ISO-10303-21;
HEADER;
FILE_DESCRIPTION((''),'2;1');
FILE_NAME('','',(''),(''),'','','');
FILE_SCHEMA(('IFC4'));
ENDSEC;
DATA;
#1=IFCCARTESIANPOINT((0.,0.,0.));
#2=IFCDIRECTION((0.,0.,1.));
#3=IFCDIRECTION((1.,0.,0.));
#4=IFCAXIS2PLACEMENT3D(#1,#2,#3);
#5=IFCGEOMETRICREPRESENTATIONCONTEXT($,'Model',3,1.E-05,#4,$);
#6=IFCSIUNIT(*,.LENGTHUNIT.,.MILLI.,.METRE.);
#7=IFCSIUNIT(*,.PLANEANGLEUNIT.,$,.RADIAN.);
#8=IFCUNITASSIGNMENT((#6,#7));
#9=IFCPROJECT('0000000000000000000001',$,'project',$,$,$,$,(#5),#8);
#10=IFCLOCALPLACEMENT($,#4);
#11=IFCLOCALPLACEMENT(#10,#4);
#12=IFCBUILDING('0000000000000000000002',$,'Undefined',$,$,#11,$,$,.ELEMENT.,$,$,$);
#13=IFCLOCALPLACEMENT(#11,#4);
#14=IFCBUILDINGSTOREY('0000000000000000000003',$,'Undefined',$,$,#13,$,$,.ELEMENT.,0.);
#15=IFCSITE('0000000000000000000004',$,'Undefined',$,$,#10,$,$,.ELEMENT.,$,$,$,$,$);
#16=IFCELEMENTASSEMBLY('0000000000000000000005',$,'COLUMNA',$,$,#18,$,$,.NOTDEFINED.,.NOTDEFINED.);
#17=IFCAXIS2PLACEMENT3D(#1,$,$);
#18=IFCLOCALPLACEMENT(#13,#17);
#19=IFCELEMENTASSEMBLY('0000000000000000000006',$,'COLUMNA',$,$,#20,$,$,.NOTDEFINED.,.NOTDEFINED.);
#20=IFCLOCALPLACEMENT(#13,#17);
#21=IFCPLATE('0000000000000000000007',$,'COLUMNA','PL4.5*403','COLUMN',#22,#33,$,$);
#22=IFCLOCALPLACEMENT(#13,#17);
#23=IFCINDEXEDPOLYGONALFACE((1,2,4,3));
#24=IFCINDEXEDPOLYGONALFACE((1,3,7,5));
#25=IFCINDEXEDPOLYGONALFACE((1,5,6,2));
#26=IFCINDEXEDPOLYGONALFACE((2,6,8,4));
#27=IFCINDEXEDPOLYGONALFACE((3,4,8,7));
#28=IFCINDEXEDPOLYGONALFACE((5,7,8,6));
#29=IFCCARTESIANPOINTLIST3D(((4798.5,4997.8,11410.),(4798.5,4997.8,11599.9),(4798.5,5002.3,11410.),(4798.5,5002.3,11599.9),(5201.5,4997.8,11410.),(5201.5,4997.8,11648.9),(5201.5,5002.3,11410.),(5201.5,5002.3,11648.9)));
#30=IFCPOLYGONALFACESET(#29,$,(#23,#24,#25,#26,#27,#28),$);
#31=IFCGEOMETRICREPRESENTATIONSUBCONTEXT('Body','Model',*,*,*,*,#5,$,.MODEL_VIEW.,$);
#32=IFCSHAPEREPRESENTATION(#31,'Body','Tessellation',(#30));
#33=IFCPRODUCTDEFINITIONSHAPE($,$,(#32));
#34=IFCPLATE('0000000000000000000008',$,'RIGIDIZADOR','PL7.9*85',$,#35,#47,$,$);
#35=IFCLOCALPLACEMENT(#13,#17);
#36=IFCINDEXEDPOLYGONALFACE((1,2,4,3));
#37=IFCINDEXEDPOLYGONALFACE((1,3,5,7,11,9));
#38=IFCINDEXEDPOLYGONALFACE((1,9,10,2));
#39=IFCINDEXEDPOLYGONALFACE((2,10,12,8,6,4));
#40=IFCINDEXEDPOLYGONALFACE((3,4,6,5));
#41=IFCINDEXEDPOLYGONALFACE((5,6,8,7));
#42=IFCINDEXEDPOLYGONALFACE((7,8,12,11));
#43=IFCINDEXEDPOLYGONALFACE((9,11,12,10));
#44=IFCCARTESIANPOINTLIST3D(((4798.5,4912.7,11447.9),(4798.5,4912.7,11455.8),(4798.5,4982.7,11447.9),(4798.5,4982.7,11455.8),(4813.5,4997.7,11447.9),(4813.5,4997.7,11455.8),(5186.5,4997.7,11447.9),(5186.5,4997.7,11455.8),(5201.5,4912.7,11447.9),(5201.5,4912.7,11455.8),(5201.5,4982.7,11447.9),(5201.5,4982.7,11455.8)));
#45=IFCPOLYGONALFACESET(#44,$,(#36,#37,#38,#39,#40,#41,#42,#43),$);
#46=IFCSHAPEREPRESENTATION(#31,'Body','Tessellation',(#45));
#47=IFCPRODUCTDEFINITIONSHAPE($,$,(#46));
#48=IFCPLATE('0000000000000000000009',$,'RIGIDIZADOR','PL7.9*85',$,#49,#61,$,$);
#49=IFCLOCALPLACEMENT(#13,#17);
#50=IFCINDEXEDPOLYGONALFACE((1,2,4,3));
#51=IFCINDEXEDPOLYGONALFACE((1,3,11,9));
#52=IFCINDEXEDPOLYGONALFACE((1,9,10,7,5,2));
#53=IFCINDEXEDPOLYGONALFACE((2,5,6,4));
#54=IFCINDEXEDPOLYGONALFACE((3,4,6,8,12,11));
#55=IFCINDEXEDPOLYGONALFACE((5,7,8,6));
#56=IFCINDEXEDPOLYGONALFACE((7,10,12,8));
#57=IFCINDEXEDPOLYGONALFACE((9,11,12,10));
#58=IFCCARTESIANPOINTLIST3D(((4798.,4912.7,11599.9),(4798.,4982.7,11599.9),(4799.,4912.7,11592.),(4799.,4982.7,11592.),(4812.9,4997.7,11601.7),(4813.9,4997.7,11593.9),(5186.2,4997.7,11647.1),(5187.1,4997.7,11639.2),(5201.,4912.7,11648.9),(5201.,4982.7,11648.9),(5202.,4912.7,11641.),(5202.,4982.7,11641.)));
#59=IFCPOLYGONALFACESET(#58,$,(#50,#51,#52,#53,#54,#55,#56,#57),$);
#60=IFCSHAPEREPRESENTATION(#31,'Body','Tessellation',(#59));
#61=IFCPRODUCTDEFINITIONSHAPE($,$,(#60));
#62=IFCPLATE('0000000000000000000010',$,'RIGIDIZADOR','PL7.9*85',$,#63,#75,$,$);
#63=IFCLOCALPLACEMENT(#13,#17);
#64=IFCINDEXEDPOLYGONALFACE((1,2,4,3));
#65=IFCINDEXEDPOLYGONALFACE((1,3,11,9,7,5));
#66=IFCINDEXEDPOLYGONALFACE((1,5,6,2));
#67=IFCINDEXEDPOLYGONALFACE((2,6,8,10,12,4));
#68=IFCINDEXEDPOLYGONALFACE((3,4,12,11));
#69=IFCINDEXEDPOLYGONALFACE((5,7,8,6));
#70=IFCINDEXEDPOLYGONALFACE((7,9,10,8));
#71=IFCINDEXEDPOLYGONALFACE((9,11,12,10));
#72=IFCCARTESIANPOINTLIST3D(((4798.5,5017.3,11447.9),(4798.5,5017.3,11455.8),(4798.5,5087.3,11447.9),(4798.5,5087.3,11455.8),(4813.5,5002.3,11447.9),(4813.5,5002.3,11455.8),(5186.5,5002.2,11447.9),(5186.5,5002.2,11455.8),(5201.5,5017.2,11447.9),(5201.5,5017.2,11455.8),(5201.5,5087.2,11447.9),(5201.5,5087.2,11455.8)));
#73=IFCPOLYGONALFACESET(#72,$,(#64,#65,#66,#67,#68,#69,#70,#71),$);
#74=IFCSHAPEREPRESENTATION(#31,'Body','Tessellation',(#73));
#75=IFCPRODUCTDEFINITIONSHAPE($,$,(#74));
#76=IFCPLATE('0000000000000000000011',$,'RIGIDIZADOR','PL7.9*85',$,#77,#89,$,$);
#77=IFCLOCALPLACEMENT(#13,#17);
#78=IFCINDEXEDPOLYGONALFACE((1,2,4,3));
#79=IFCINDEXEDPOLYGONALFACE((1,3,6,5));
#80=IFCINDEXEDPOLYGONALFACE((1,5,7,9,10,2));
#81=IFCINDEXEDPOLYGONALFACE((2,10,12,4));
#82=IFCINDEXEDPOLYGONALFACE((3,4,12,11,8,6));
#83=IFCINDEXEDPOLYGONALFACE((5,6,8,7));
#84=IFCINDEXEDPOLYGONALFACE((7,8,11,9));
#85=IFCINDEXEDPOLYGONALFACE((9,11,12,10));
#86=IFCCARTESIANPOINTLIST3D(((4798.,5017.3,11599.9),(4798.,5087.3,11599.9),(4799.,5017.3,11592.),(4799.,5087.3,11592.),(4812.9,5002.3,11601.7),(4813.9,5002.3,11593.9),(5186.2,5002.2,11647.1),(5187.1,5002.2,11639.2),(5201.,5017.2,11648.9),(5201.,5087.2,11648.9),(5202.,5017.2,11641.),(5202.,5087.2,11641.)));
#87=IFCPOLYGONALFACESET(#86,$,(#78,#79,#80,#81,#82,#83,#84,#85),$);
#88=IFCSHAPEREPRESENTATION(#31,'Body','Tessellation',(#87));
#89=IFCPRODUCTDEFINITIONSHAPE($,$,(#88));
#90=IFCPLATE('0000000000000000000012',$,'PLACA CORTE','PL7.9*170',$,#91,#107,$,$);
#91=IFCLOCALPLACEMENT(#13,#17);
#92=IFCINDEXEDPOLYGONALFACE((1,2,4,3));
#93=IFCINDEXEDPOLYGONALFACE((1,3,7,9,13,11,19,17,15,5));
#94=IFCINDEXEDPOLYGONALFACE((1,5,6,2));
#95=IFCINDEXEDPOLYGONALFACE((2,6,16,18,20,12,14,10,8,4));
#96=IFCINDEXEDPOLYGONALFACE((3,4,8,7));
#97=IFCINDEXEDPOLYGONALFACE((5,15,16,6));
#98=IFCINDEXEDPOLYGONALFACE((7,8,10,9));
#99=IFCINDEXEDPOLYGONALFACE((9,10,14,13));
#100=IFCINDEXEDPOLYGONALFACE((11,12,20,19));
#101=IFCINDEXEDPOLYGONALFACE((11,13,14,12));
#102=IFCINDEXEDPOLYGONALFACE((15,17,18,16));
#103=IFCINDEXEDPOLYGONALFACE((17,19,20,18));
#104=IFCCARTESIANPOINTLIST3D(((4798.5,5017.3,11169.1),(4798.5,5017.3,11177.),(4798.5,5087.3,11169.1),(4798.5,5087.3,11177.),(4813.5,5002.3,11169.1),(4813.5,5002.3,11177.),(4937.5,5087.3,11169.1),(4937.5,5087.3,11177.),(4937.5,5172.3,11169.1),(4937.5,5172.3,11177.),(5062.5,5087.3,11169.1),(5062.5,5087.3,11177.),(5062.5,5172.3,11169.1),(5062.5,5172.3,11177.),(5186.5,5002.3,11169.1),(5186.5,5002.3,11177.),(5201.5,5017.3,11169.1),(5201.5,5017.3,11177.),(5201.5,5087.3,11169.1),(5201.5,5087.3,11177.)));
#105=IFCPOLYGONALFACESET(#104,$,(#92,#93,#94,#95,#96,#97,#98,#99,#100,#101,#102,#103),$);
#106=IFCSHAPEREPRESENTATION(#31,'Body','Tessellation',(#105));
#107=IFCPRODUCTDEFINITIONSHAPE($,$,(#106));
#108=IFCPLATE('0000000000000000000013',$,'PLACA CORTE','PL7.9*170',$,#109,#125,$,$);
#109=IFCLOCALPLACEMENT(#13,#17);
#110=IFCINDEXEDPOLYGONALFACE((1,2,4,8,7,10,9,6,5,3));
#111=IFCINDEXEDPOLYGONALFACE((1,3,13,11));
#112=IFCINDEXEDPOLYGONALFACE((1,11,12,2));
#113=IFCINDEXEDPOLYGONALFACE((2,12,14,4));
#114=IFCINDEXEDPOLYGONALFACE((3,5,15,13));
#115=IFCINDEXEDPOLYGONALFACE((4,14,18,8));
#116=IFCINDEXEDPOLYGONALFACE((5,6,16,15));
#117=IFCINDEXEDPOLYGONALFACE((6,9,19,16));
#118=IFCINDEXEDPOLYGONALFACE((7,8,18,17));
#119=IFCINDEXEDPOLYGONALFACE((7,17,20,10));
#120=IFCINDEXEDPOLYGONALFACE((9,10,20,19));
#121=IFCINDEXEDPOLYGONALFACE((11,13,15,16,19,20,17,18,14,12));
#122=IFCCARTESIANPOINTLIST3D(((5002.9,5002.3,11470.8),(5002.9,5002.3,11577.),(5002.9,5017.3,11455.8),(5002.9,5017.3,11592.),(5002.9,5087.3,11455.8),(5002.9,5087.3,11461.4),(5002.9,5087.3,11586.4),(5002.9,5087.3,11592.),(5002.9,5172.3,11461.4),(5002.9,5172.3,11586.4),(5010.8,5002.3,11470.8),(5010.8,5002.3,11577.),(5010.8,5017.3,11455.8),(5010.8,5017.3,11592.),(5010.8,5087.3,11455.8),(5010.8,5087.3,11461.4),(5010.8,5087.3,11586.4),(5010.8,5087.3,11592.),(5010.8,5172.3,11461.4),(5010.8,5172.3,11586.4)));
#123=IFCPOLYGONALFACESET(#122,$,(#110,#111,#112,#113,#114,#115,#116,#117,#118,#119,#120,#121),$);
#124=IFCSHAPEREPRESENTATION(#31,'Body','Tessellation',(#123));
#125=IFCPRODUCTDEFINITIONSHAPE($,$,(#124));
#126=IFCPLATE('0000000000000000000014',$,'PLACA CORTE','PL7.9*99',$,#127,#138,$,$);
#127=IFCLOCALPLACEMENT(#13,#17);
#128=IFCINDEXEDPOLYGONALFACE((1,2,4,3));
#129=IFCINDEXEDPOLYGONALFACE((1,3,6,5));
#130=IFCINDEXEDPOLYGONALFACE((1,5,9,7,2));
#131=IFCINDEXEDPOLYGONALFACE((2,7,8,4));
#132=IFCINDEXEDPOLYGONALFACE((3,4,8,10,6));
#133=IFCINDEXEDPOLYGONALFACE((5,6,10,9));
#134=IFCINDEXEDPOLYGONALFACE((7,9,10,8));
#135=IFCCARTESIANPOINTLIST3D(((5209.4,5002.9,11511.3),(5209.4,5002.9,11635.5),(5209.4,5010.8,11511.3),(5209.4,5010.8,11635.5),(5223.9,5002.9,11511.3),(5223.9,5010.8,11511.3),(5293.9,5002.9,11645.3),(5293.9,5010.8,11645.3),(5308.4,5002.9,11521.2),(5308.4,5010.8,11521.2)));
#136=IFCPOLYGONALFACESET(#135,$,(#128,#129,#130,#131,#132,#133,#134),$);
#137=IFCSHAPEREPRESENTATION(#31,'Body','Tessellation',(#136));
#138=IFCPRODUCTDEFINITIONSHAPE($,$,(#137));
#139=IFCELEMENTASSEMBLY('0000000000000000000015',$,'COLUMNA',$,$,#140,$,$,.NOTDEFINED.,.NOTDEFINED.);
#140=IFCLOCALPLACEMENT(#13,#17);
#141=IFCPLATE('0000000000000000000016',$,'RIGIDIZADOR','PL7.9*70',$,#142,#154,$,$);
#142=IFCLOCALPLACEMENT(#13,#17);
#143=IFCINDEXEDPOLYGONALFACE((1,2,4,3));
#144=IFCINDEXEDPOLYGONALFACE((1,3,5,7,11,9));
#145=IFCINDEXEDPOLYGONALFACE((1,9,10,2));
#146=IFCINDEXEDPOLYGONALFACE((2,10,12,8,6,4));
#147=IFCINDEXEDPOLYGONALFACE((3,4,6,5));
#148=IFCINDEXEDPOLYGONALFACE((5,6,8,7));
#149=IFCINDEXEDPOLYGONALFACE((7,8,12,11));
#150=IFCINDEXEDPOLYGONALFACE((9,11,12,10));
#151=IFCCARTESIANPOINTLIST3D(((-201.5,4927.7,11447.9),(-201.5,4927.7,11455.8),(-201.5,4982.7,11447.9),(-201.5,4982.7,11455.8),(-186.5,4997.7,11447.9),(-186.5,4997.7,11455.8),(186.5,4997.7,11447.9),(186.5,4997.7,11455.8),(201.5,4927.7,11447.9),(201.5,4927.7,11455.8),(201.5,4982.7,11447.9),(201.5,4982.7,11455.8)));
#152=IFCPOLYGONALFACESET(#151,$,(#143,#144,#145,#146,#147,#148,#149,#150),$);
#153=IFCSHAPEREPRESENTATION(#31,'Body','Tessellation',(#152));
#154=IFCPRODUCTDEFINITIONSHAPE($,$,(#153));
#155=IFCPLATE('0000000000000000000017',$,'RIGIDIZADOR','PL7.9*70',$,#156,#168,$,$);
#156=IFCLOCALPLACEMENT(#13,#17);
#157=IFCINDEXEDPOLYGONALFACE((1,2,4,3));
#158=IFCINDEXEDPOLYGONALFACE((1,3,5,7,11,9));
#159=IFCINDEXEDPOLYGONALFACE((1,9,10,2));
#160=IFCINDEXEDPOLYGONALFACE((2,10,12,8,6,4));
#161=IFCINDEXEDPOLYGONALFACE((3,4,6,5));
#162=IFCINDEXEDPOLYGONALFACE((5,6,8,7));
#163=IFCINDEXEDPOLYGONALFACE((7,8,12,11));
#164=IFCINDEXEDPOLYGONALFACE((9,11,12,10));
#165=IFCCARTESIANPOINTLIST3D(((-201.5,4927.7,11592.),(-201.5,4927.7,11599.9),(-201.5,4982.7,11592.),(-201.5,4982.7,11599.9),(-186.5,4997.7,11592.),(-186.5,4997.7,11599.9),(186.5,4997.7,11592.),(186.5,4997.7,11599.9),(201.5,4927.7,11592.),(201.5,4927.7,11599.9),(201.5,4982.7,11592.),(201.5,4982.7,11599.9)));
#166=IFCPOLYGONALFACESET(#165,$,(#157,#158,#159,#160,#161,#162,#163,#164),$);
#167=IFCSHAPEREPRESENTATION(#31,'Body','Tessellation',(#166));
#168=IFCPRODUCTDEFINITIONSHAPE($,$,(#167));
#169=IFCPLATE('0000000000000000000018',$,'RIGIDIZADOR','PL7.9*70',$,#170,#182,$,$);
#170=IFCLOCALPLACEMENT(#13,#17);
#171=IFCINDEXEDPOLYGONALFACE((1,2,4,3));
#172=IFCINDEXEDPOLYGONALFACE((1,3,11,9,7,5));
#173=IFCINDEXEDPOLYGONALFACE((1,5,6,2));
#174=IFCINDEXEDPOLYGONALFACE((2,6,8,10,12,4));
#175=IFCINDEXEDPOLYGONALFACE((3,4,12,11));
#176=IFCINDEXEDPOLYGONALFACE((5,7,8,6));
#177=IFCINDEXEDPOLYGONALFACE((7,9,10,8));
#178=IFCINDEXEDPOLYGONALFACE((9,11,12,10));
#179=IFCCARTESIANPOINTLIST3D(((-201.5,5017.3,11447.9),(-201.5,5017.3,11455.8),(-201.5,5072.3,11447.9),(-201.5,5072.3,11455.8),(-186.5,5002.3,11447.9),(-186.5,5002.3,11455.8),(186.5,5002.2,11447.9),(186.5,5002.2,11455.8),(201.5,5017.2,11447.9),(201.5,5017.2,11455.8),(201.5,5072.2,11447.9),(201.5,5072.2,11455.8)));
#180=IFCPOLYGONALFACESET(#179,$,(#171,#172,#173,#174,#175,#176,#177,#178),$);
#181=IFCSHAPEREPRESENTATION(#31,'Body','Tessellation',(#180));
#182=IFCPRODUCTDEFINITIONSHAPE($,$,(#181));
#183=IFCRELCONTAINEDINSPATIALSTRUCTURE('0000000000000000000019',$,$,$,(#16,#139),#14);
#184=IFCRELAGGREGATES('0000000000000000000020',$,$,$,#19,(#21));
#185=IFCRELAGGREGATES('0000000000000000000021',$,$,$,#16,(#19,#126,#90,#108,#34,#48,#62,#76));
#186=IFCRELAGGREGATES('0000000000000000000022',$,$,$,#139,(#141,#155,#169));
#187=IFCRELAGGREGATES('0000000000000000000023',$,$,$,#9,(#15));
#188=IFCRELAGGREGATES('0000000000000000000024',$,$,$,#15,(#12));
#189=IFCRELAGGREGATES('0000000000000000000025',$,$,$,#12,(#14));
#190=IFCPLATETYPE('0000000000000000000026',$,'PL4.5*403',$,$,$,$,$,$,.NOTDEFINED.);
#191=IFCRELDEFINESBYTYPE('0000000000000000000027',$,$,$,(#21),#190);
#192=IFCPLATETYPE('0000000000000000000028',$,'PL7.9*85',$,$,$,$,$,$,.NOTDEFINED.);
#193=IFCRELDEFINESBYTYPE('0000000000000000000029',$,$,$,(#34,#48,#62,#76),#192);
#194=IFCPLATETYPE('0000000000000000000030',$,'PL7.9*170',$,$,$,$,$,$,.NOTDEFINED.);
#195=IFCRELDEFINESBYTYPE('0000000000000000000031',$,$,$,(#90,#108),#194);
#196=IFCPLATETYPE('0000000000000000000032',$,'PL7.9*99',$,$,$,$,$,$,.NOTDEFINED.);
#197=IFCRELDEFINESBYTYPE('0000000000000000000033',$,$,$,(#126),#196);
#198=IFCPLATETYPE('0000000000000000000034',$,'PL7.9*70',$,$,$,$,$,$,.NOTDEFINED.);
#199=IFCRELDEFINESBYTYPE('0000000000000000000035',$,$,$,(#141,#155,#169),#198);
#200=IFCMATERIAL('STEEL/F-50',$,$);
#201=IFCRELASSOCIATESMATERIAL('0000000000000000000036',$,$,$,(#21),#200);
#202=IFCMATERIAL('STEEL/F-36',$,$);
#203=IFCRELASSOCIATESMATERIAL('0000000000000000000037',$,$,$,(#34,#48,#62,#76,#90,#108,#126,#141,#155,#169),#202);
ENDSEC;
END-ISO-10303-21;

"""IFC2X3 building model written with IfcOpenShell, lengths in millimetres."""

from ifc_helpers import new_model, si_unit, frame, origin_with_axes, place, context, subcontext, project, spatial, polyline, outline, extrude, boolean, material, type_object, element, aggregate, save


model = new_model("IFC2X3")

# Units and contexts
model_context = context("Model", 3, precision=1e-05, world=origin_with_axes())
body_context = subcontext(model_context, "Body", "Model", "MODEL_VIEW")
ifc_project = project(units=[si_unit("LENGTHUNIT", "METRE", prefix="MILLI"), si_unit("PLANEANGLEUNIT", "RADIAN")], contexts=[model_context])

# Site, building, storey
site_placement = place(None, origin_with_axes())
site = spatial("IfcSite", under=ifc_project, at=site_placement, Name="Undefined", CompositionType="ELEMENT")
building_placement = place(site_placement, origin_with_axes())
building = spatial("IfcBuilding", under=site, at=building_placement, Name="Undefined", CompositionType="ELEMENT")
storey_placement = place(building_placement, origin_with_axes())
storey = spatial("IfcBuildingStorey", under=building, at=storey_placement, Name="Undefined", CompositionType="ELEMENT", Elevation=0.0)

# Shared definitions
ifc_material_1 = material(Name="STEEL/F-36")

# Element assembly
assembly_1_placement = place(storey_placement, origin_with_axes())
assembly_1 = element("IfcElementAssembly", 1, at=assembly_1_placement, inside=storey, Name="COLUMNA", AssemblyPlace="NOTDEFINED", PredefinedType="NOTDEFINED")

# Element assembly, plate
assembly_2_placement = place(assembly_1_placement, origin_with_axes())
assembly_2 = element("IfcElementAssembly", 2, at=assembly_2_placement, Name="COLUMNA", AssemblyPlace="NOTDEFINED", PredefinedType="NOTDEFINED")
ifc_material_2 = material(Name="STEEL/F-50")
plate_type_1 = type_object("IfcPlateType", Name="PL4.5*403", PredefinedType="NOTDEFINED")
plate_1_placement = place(assembly_2_placement, frame((5000.0, 5000.0, 11410.0), z_axis=(0.0, -1.0, 0.0), x_axis=(0.000002, 0.0, 1.0)))
plate_1 = element("IfcPlate", 3, at=plate_1_placement, type_object=plate_type_1, material=ifc_material_2, Name="COLUMNA", Description="PL4.5*403", ObjectType="COLUMN", context=body_context, shape_type="CSG", body=[
    boolean("DIFFERENCE", extrude(outline(polyline([(0.0, -201.5), (0.0, 201.5), (238.9, 201.5), (238.9, -201.5), (0.0, -201.5)])), frame((0.0, 0.0, -2.2), z_axis=(0.0, 0.0, 1.0), x_axis=(1.0, 0.0, 0.0)), (0.0, 0.0, 1.0), 4.5), extrude(outline(polyline([(0.0, 0.0), (49.0, 0.0), (0.0, 403.0), (0.0, 0.0)])), frame((238.9, 201.5, -5.0), z_axis=(0.0, 0.0, 1.0), x_axis=(-1.0, 0.0, 0.0)), (0.0, 0.0, 1.0), 10.0)),
])
aggregate(assembly_2, [plate_1])

# Plates
plate_type_2 = type_object("IfcPlateType", Name="PL7.9*85", PredefinedType="NOTDEFINED")
plate_2_placement = place(assembly_1_placement, frame((5201.5, 4997.7, 11451.9), z_axis=(0.0, 0.0, -1.0), x_axis=(0.0, -1.0, 0.0)))
plate_2 = element("IfcPlate", 4, at=plate_2_placement, type_object=plate_type_2, material=ifc_material_1, Name="RIGIDIZADOR", Description="PL7.9*85", context=body_context, shape_type="SweptSolid", body=[
    extrude(outline(polyline([(0.0, 15.0), (15.0, 0.0), (85.0, 0.0), (85.0, 403.0), (15.0, 403.0), (0.0, 388.0), (0.0, 15.0)])), frame((0.0, 0.0, -4.0), z_axis=(0.0, 0.0, 1.0), x_axis=(1.0, 0.0, 0.0)), (0.0, 0.0, 1.0), 7.9),
])
plate_3_placement = place(assembly_1_placement, frame((5201.5, 4997.7, 11645.0), z_axis=(0.120699, 0.0, -0.992689), x_axis=(0.0, -1.0, 0.0)))
plate_3 = element("IfcPlate", 5, at=plate_3_placement, type_object=plate_type_2, material=ifc_material_1, Name="RIGIDIZADOR", Description="PL7.9*85", context=body_context, shape_type="SweptSolid", body=[
    extrude(outline(polyline([(0.0, 15.0), (15.0, 0.0), (85.0, 0.0), (85.0, 406.0), (15.0, 406.0), (0.0, 391.0), (0.0, 15.0)])), frame((0.0, 0.0, -4.0), z_axis=(0.0, 0.0, 1.0), x_axis=(1.0, 0.0, 0.0)), (0.0, 0.0, 1.0), 7.9),
])
plate_4_placement = place(assembly_1_placement, frame((5201.5, 5002.2, 11451.9), z_axis=(0.0, 0.0, 1.0), x_axis=(0.0, 1.0, 0.0)))
plate_4 = element("IfcPlate", 6, at=plate_4_placement, type_object=plate_type_2, material=ifc_material_1, Name="RIGIDIZADOR", Description="PL7.9*85", context=body_context, shape_type="SweptSolid", body=[
    extrude(outline(polyline([(0.0, 15.0), (15.0, 0.0), (85.0, 0.0), (85.0, 403.0), (15.0, 403.0), (0.0, 388.0), (0.0, 15.0)])), frame((0.0, 0.0, -4.0), z_axis=(0.0, 0.0, 1.0), x_axis=(1.0, 0.0, 0.0)), (0.0, 0.0, 1.0), 7.9),
])
plate_5_placement = place(assembly_1_placement, frame((5201.5, 5002.2, 11645.0), z_axis=(-0.120699, 0.0, 0.992689), x_axis=(0.0, 1.0, 0.0)))
plate_5 = element("IfcPlate", 7, at=plate_5_placement, type_object=plate_type_2, material=ifc_material_1, Name="RIGIDIZADOR", Description="PL7.9*85", context=body_context, shape_type="SweptSolid", body=[
    extrude(outline(polyline([(0.0, 15.0), (15.0, 0.0), (85.0, 0.0), (85.0, 406.0), (15.0, 406.0), (0.0, 391.0), (0.0, 15.0)])), frame((0.0, 0.0, -4.0), z_axis=(0.0, 0.0, 1.0), x_axis=(1.0, 0.0, 0.0)), (0.0, 0.0, 1.0), 7.9),
])
plate_type_3 = type_object("IfcPlateType", Name="PL7.9*170", PredefinedType="NOTDEFINED")
plate_6_placement = place(assembly_1_placement, frame((4798.5, 5002.3, 11173.1), z_axis=(0.0, 0.0, 1.0), x_axis=(1.0, 0.0, 0.0)))
plate_6 = element("IfcPlate", 8, at=plate_6_placement, type_object=plate_type_3, material=ifc_material_1, Name="PLACA CORTE", Description="PL7.9*170", context=body_context, shape_type="SweptSolid", body=[
    extrude(outline(polyline([(0.0, 15.0), (15.0, 0.0), (388.0, 0.0), (403.0, 15.0), (403.0, 85.0), (264.0, 85.0), (264.0, 170.0), (139.0, 170.0), (139.0, 85.0), (0.0, 85.0), (0.0, 15.0)])), frame((0.0, 0.0, -4.0), z_axis=(0.0, 0.0, 1.0), x_axis=(1.0, 0.0, 0.0)), (0.0, 0.0, 1.0), 7.9),
])
plate_7_placement = place(assembly_1_placement, frame((5006.9, 5002.3, 11592.0), z_axis=(1.0, 0.0, 0.0), x_axis=(0.0, 0.0, -1.0)))
plate_7 = element("IfcPlate", 9, at=plate_7_placement, type_object=plate_type_3, material=ifc_material_1, Name="PLACA CORTE", Description="PL7.9*170", context=body_context, shape_type="SweptSolid", body=[
    extrude(outline(polyline([(0.0, 15.0), (15.0, 0.0), (121.2, 0.0), (136.2, 15.0), (136.2, 85.0), (130.6, 85.0), (130.6, 170.0), (5.6, 170.0), (5.6, 85.0), (0.0, 85.0), (0.0, 15.0)])), frame((0.0, 0.0, -4.0), z_axis=(0.0, 0.0, 1.0), x_axis=(1.0, 0.0, 0.0)), (0.0, 0.0, 1.0), 7.9),
])
plate_type_4 = type_object("IfcPlateType", Name="PL7.9*99", PredefinedType="NOTDEFINED")
plate_8_placement = place(assembly_1_placement, frame((5209.4, 5006.8, 11635.5), z_axis=(0.000002, 1.0, 0.0), x_axis=(0.993239, -0.000002, 0.11609)))
plate_8 = element("IfcPlate", 10, at=plate_8_placement, type_object=plate_type_4, material=ifc_material_1, Name="PLACA CORTE", Description="PL7.9*99", context=body_context, shape_type="SweptSolid", body=[
    extrude(outline(polyline([(0.0, 0.0), (85.0, 0.0), (85.0, 125.0), (0.0, 125.0), (-14.4, 123.3), (0.0, 0.0)])), frame((0.0, 0.0, -4.0), z_axis=(0.0, 0.0, 1.0), x_axis=(1.0, 0.0, 0.0)), (0.0, 0.0, 1.0), 7.9),
])
aggregate(assembly_1, [assembly_2, plate_8, plate_6, plate_7, plate_2, plate_3, plate_4, plate_5])

# Element assembly, plates
assembly_3_placement = place(storey_placement, origin_with_axes())
assembly_3 = element("IfcElementAssembly", 11, at=assembly_3_placement, inside=storey, Name="COLUMNA", AssemblyPlace="NOTDEFINED", PredefinedType="NOTDEFINED")
plate_type_5 = type_object("IfcPlateType", Name="PL7.9*70", PredefinedType="NOTDEFINED")
plate_9_placement = place(assembly_3_placement, frame((201.5, 4997.7, 11451.9), z_axis=(0.0, 0.0, -1.0), x_axis=(0.0, -1.0, 0.0)))
plate_9 = element("IfcPlate", 12, at=plate_9_placement, type_object=plate_type_5, material=ifc_material_1, Name="RIGIDIZADOR", Description="PL7.9*70", context=body_context, shape_type="SweptSolid", body=[
    extrude(outline(polyline([(0.0, 15.0), (15.0, 0.0), (70.0, 0.0), (70.0, 403.0), (15.0, 403.0), (0.0, 388.0), (0.0, 15.0)])), frame((0.0, 0.0, -4.0), z_axis=(0.0, 0.0, 1.0), x_axis=(1.0, 0.0, 0.0)), (0.0, 0.0, 1.0), 7.9),
])
plate_10_placement = place(assembly_3_placement, frame((201.5, 4997.7, 11596.0), z_axis=(0.0, 0.0, -1.0), x_axis=(0.0, -1.0, 0.0)))
plate_10 = element("IfcPlate", 13, at=plate_10_placement, type_object=plate_type_5, material=ifc_material_1, Name="RIGIDIZADOR", Description="PL7.9*70", context=body_context, shape_type="SweptSolid", body=[
    extrude(outline(polyline([(0.0, 15.0), (15.0, 0.0), (70.0, 0.0), (70.0, 403.0), (15.0, 403.0), (0.0, 388.0), (0.0, 15.0)])), frame((0.0, 0.0, -4.0), z_axis=(0.0, 0.0, 1.0), x_axis=(1.0, 0.0, 0.0)), (0.0, 0.0, 1.0), 7.9),
])
plate_11_placement = place(assembly_3_placement, frame((201.5, 5002.2, 11451.9), z_axis=(0.0, 0.0, 1.0), x_axis=(0.0, 1.0, 0.0)))
plate_11 = element("IfcPlate", 14, at=plate_11_placement, type_object=plate_type_5, material=ifc_material_1, Name="RIGIDIZADOR", Description="PL7.9*70", context=body_context, shape_type="SweptSolid", body=[
    extrude(outline(polyline([(0.0, 15.0), (15.0, 0.0), (70.0, 0.0), (70.0, 403.0), (15.0, 403.0), (0.0, 388.0), (0.0, 15.0)])), frame((0.0, 0.0, -4.0), z_axis=(0.0, 0.0, 1.0), x_axis=(1.0, 0.0, 0.0)), (0.0, 0.0, 1.0), 7.9),
])
aggregate(assembly_3, [plate_9, plate_10, plate_11])

save(model, "model.ifc")
